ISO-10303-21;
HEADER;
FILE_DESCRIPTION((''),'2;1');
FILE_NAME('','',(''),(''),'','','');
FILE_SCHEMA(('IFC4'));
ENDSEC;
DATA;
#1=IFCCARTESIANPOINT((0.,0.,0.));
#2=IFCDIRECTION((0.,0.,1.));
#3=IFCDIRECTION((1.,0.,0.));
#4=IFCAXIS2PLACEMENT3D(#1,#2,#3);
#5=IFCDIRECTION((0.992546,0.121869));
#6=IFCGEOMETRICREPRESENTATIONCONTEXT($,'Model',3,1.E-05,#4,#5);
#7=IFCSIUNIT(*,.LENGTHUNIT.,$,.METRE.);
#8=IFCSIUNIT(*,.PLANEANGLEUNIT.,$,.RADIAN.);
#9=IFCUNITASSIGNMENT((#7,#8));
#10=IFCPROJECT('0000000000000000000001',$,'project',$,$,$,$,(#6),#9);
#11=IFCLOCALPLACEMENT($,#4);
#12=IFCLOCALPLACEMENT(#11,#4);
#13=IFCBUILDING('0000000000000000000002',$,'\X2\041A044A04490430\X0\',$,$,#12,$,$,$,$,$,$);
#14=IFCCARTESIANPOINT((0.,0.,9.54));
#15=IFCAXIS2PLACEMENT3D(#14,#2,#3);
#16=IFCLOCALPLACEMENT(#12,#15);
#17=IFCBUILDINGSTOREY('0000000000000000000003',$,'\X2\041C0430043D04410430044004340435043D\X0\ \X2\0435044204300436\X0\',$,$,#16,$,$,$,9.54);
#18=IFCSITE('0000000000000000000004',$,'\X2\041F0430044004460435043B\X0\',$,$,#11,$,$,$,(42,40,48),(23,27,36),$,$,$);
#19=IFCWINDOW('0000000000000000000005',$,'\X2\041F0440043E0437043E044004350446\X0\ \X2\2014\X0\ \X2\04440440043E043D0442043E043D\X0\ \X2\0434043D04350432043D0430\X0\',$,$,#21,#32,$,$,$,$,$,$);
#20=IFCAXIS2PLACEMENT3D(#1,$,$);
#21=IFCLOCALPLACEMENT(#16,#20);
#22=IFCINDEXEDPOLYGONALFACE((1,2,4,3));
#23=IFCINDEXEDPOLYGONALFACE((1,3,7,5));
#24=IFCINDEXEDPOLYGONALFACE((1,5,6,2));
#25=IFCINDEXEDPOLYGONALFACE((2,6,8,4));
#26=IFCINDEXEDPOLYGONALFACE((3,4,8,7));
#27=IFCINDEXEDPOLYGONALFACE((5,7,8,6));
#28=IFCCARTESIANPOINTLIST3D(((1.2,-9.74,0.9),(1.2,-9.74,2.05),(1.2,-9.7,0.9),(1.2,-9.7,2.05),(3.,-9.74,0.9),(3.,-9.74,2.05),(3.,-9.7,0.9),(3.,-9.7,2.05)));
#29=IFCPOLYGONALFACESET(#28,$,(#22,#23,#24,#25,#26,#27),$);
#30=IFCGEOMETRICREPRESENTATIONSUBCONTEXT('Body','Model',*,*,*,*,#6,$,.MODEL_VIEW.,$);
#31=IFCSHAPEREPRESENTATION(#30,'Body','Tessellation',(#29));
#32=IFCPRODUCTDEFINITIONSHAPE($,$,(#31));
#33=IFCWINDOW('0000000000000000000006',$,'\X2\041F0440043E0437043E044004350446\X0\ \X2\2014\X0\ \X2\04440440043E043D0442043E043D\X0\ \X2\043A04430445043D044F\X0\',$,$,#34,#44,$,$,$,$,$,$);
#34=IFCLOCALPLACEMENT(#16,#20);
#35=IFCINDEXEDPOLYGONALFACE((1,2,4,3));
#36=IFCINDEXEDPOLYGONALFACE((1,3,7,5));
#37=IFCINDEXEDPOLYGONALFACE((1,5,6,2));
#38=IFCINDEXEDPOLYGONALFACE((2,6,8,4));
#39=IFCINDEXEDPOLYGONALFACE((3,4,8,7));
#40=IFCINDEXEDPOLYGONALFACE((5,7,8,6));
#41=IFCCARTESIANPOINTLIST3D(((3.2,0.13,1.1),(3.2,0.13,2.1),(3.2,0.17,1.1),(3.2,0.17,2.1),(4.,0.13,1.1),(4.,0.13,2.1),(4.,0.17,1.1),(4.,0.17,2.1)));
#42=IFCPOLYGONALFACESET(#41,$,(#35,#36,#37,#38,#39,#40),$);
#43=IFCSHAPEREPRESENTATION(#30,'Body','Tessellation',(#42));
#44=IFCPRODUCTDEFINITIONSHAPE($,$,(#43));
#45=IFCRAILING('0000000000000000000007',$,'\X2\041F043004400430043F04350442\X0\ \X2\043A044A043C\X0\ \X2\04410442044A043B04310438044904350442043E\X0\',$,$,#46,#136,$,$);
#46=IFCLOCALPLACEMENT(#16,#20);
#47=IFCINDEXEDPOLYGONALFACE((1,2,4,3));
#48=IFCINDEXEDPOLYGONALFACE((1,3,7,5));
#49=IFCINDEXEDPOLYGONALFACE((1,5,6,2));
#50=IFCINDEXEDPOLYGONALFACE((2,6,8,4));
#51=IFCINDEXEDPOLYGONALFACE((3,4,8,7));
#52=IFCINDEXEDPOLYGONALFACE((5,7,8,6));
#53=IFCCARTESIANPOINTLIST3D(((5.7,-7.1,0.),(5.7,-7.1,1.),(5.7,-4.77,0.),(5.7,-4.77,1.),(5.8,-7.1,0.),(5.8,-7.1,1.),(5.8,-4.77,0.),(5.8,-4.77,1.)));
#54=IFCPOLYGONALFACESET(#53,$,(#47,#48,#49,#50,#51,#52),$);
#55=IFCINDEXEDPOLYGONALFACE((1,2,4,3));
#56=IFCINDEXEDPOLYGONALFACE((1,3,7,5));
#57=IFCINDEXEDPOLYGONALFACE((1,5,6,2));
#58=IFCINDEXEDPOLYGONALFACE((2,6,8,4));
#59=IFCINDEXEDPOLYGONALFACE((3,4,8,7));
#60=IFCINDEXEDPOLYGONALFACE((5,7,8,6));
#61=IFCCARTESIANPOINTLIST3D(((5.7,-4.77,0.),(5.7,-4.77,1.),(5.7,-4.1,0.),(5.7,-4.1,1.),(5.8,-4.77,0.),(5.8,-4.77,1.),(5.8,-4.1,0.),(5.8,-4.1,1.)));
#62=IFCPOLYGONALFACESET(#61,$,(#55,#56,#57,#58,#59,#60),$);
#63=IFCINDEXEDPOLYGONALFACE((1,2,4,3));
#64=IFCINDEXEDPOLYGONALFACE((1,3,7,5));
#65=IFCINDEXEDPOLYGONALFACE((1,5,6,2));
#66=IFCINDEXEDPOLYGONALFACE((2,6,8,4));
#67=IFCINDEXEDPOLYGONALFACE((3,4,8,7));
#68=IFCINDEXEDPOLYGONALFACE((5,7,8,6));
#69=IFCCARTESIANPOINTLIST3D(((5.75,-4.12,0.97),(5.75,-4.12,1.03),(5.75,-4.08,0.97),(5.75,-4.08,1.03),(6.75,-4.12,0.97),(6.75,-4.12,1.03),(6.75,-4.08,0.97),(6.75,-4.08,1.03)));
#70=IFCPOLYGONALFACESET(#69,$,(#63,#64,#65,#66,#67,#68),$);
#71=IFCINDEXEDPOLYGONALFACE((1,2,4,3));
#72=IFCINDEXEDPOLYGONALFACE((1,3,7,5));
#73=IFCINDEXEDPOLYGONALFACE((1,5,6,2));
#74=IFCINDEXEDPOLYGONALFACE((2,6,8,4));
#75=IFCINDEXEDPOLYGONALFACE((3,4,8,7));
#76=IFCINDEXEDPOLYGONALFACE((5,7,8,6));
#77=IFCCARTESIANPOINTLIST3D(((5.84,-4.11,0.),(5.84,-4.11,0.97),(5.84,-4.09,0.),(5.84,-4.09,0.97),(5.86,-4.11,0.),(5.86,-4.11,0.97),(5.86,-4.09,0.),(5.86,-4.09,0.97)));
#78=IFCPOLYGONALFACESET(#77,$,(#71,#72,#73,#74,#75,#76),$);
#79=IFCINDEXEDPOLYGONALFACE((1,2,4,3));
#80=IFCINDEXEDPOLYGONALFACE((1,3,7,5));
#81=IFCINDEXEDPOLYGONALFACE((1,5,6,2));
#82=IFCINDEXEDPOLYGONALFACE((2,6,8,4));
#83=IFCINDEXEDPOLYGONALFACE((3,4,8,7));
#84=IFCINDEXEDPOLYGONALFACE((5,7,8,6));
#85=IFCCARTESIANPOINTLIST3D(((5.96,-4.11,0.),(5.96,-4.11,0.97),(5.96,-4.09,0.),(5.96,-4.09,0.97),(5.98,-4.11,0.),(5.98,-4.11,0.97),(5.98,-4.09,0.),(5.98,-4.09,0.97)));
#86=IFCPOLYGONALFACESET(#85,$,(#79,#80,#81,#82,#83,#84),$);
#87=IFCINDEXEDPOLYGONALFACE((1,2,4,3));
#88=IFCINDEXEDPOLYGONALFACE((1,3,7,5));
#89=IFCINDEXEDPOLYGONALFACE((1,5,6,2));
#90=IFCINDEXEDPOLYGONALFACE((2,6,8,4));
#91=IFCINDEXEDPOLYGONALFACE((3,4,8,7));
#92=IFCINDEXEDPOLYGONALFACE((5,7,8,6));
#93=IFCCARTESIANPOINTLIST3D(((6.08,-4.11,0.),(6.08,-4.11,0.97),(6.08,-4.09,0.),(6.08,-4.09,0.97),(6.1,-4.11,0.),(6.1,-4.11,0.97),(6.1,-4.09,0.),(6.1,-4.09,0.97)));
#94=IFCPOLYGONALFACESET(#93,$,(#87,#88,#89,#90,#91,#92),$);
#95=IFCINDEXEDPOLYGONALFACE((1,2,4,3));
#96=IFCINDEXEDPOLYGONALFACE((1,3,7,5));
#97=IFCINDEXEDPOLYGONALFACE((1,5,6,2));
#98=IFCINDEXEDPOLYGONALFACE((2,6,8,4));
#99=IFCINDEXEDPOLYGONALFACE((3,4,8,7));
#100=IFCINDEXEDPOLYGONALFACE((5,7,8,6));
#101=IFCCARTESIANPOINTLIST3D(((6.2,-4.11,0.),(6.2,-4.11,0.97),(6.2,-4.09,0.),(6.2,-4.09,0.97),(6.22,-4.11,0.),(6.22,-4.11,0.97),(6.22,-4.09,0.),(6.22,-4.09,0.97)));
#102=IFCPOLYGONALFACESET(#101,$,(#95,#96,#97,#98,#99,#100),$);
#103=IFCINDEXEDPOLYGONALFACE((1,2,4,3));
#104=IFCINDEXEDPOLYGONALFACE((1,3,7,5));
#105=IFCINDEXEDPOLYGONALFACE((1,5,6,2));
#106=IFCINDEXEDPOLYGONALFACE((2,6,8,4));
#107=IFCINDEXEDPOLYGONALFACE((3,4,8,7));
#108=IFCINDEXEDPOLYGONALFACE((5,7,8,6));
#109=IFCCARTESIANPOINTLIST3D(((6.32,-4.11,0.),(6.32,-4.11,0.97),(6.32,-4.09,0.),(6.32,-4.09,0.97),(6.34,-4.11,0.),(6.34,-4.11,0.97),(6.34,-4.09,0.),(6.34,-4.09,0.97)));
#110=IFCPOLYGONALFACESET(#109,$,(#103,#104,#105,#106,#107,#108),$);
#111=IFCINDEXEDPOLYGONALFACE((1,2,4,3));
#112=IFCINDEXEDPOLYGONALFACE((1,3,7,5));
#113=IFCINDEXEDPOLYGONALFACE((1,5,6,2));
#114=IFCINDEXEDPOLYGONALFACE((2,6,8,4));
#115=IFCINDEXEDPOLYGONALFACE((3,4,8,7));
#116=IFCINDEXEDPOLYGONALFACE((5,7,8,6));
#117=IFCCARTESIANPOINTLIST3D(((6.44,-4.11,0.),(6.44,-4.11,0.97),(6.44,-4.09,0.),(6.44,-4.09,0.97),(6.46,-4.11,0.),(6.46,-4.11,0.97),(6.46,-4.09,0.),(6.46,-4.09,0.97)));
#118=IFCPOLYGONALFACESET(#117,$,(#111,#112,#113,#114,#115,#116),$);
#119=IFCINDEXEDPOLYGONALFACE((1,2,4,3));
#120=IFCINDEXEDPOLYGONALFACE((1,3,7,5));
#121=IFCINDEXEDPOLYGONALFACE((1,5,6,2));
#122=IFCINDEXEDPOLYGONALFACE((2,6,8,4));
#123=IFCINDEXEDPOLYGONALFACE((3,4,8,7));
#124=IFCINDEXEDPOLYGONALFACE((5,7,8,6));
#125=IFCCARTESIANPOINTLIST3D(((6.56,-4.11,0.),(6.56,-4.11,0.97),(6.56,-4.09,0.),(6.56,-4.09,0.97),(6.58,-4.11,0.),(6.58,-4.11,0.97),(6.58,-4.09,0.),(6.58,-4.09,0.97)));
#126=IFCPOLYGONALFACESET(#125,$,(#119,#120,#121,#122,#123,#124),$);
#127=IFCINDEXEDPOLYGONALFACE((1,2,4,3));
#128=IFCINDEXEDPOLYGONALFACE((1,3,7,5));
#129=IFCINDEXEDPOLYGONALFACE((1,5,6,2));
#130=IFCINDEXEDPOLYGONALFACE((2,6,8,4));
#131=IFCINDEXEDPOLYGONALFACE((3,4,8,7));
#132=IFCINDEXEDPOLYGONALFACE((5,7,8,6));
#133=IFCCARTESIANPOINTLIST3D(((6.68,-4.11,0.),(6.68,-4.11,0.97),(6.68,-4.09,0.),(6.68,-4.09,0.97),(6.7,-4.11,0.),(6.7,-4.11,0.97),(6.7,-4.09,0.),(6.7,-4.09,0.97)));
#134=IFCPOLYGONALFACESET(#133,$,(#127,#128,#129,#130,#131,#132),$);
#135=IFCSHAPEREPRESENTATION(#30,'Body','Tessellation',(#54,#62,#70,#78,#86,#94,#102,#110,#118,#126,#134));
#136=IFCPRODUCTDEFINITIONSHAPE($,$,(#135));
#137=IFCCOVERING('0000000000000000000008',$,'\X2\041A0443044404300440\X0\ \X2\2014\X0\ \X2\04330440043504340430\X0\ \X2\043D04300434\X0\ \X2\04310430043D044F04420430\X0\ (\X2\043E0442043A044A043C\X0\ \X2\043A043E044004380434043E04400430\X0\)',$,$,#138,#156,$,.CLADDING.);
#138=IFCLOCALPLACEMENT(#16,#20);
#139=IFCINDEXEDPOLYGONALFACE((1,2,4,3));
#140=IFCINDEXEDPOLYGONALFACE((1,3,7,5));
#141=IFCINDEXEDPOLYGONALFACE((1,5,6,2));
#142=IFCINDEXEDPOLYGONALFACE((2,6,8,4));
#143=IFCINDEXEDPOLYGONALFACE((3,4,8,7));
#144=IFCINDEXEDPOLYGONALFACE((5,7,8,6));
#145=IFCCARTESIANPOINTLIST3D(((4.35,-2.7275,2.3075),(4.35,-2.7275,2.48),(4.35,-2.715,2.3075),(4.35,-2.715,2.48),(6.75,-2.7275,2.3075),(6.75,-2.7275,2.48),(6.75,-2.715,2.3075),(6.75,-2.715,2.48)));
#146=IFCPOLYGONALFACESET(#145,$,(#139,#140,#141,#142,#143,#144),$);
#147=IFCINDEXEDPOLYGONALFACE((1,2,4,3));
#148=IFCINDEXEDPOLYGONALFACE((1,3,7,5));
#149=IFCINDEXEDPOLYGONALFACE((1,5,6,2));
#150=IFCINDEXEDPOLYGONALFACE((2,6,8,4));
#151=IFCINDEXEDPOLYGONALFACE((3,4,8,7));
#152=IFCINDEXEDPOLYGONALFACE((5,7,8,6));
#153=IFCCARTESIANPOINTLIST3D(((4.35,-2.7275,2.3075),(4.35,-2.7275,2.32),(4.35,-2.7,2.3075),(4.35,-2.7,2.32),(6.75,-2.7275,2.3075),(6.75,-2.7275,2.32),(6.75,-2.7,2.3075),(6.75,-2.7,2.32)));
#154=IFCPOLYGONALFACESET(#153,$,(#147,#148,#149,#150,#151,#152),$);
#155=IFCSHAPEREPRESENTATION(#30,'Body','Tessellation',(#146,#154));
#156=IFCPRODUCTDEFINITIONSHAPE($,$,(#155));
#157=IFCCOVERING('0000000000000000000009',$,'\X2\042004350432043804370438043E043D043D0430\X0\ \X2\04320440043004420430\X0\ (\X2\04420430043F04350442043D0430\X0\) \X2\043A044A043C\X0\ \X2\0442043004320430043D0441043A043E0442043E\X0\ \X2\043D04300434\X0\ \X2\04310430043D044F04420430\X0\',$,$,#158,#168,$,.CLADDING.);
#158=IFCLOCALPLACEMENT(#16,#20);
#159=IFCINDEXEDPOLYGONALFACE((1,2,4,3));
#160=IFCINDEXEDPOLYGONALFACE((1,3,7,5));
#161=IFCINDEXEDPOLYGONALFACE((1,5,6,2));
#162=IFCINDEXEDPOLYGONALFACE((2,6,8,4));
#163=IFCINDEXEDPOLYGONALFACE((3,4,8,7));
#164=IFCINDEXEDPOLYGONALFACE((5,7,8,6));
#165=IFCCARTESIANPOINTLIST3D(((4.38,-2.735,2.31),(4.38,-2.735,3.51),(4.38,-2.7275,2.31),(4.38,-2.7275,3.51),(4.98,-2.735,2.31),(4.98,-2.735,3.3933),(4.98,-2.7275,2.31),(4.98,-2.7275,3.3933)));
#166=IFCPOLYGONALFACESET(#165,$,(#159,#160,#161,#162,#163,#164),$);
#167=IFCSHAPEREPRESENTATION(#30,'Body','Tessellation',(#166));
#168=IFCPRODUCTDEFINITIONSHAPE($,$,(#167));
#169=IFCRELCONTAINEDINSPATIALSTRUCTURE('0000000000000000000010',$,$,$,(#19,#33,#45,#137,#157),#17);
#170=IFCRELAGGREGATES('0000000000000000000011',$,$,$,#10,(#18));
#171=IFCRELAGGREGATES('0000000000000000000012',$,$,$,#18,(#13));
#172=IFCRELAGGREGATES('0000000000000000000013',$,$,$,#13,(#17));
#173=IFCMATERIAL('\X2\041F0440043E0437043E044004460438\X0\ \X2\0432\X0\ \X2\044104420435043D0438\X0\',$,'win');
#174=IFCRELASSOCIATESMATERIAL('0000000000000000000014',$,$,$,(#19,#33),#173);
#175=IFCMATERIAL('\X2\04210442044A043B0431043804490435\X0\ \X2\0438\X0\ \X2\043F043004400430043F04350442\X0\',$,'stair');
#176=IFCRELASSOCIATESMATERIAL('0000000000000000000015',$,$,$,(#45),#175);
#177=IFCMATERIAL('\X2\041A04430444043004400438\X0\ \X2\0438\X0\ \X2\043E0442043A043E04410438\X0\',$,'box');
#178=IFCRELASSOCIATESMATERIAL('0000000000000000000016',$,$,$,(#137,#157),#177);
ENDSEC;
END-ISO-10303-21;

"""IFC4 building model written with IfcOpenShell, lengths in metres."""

from ifc_helpers import new_model, si_unit, direction, frame, origin_with_axes, place, context, subcontext, project, spatial, polyline, outline, extrude, material, element, save


model = new_model("IFC4")

# Units and contexts
model_context = context("Model", 3, precision=1e-05, world=origin_with_axes(), true_north=direction((0.992546, 0.121869)))
body_context = subcontext(model_context, "Body", "Model", "MODEL_VIEW")
ifc_project = project(units=[si_unit("LENGTHUNIT", "METRE"), si_unit("PLANEANGLEUNIT", "RADIAN")], contexts=[model_context])

# Site, building, storey
site_placement = place(None, origin_with_axes())
site = spatial("IfcSite", under=ifc_project, at=site_placement, Name="Парцел", RefLatitude=(42, 40, 48), RefLongitude=(23, 27, 36))
building_placement = place(site_placement, origin_with_axes())
building = spatial("IfcBuilding", under=site, at=building_placement, Name="Къща")
storey_placement = place(building_placement, frame((0.0, 0.0, 9.54), z_axis=(0.0, 0.0, 1.0), x_axis=(1.0, 0.0, 0.0)))
storey = spatial("IfcBuildingStorey", under=building, at=storey_placement, Name="Мансарден етаж", Elevation=9.54)

# Windows
ifc_material_1 = material(Name="Прозорци в стени", Category="win")
window_1_placement = place(storey_placement, origin_with_axes())
element("IfcWindow", 1, at=window_1_placement, inside=storey, material=ifc_material_1, Name="Прозорец — фронтон дневна", context=body_context, shape_type="SweptSolid", body=[
    extrude(outline(polyline([(1.2, -0.9), (3.0, -0.9), (3.0, -2.05), (1.2, -2.05), (1.2, -0.9)])), frame((0.0, -9.74, 0.0), z_axis=(0.0, 1.0, 0.0), x_axis=(1.0, 0.0, 0.0)), (0.0, 0.0, 1.0), 0.04),
])
window_2_placement = place(storey_placement, origin_with_axes())
element("IfcWindow", 2, at=window_2_placement, inside=storey, material=ifc_material_1, Name="Прозорец — фронтон кухня", context=body_context, shape_type="SweptSolid", body=[
    extrude(outline(polyline([(3.2, -1.1), (4.0, -1.1), (4.0, -2.1), (3.2, -2.1), (3.2, -1.1)])), frame((0.0, 0.13, 0.0), z_axis=(0.0, 1.0, 0.0), x_axis=(1.0, 0.0, 0.0)), (0.0, 0.0, 1.0), 0.04),
])

# Shared definitions
ifc_material_2 = material(Name="Стълбище и парапет", Category="stair")

# Railing
railing_placement = place(storey_placement, origin_with_axes())
element("IfcRailing", 3, at=railing_placement, inside=storey, material=ifc_material_2, Name="Парапет към стълбището", context=body_context, shape_type="SweptSolid", body=[
    extrude(outline(polyline([(5.7, 0.0), (5.8, 0.0), (5.8, -1.0), (5.7, -1.0), (5.7, 0.0)])), frame((0.0, -7.1, 0.0), z_axis=(0.0, 1.0, 0.0), x_axis=(1.0, 0.0, 0.0)), (0.0, 0.0, 1.0), 2.33),
    extrude(outline(polyline([(5.7, 0.0), (5.8, 0.0), (5.8, -1.0), (5.7, -1.0), (5.7, 0.0)])), frame((0.0, -4.77, 0.0), z_axis=(0.0, 1.0, 0.0), x_axis=(1.0, 0.0, 0.0)), (0.0, 0.0, 1.0), 0.67),
    extrude(outline(polyline([(5.75, -0.97), (6.75, -0.97), (6.75, -1.03), (5.75, -1.03), (5.75, -0.97)])), frame((0.0, -4.12, 0.0), z_axis=(0.0, 1.0, 0.0), x_axis=(1.0, 0.0, 0.0)), (0.0, 0.0, 1.0), 0.04),
    extrude(outline(polyline([(5.84, 0.0), (5.86, 0.0), (5.86, -0.97), (5.84, -0.97), (5.84, 0.0)])), frame((0.0, -4.11, 0.0), z_axis=(0.0, 1.0, 0.0), x_axis=(1.0, 0.0, 0.0)), (0.0, 0.0, 1.0), 0.02),
    extrude(outline(polyline([(5.96, 0.0), (5.98, 0.0), (5.98, -0.97), (5.96, -0.97), (5.96, 0.0)])), frame((0.0, -4.11, 0.0), z_axis=(0.0, 1.0, 0.0), x_axis=(1.0, 0.0, 0.0)), (0.0, 0.0, 1.0), 0.02),
    extrude(outline(polyline([(6.08, 0.0), (6.1, 0.0), (6.1, -0.97), (6.08, -0.97), (6.08, 0.0)])), frame((0.0, -4.11, 0.0), z_axis=(0.0, 1.0, 0.0), x_axis=(1.0, 0.0, 0.0)), (0.0, 0.0, 1.0), 0.02),
    extrude(outline(polyline([(6.2, 0.0), (6.22, 0.0), (6.22, -0.97), (6.2, -0.97), (6.2, 0.0)])), frame((0.0, -4.11, 0.0), z_axis=(0.0, 1.0, 0.0), x_axis=(1.0, 0.0, 0.0)), (0.0, 0.0, 1.0), 0.02),
    extrude(outline(polyline([(6.32, 0.0), (6.34, 0.0), (6.34, -0.97), (6.32, -0.97), (6.32, 0.0)])), frame((0.0, -4.11, 0.0), z_axis=(0.0, 1.0, 0.0), x_axis=(1.0, 0.0, 0.0)), (0.0, 0.0, 1.0), 0.02),
    extrude(outline(polyline([(6.44, 0.0), (6.46, 0.0), (6.46, -0.97), (6.44, -0.97), (6.44, 0.0)])), frame((0.0, -4.11, 0.0), z_axis=(0.0, 1.0, 0.0), x_axis=(1.0, 0.0, 0.0)), (0.0, 0.0, 1.0), 0.02),
    extrude(outline(polyline([(6.56, 0.0), (6.58, 0.0), (6.58, -0.97), (6.56, -0.97), (6.56, 0.0)])), frame((0.0, -4.11, 0.0), z_axis=(0.0, 1.0, 0.0), x_axis=(1.0, 0.0, 0.0)), (0.0, 0.0, 1.0), 0.02),
    extrude(outline(polyline([(6.68, 0.0), (6.7, 0.0), (6.7, -0.97), (6.68, -0.97), (6.68, 0.0)])), frame((0.0, -4.11, 0.0), z_axis=(0.0, 1.0, 0.0), x_axis=(1.0, 0.0, 0.0)), (0.0, 0.0, 1.0), 0.02),
])

# Coverings
ifc_material_3 = material(Name="Куфари и откоси", Category="box")
covering_1_placement = place(storey_placement, origin_with_axes())
element("IfcCovering", 4, at=covering_1_placement, inside=storey, material=ifc_material_3, Name="Куфар — греда над банята (откъм коридора)", PredefinedType="CLADDING", context=body_context, shape_type="SweptSolid", body=[
    extrude(outline(polyline([(4.35, -2.3075), (6.75, -2.3075), (6.75, -2.48), (4.35, -2.48), (4.35, -2.3075)])), frame((0.0, -2.7275, 0.0), z_axis=(0.0, 1.0, 0.0), x_axis=(1.0, 0.0, 0.0)), (0.0, 0.0, 1.0), 0.0125),
    extrude(outline(polyline([(4.35, -2.3075), (6.75, -2.3075), (6.75, -2.32), (4.35, -2.32), (4.35, -2.3075)])), frame((0.0, -2.7275, 0.0), z_axis=(0.0, 1.0, 0.0), x_axis=(1.0, 0.0, 0.0)), (0.0, 0.0, 1.0), 0.0275),
])
covering_2_placement = place(storey_placement, origin_with_axes())
element("IfcCovering", 5, at=covering_2_placement, inside=storey, material=ifc_material_3, Name="Ревизионна врата (тапетна) към таванското над банята", PredefinedType="CLADDING", context=body_context, shape_type="SweptSolid", body=[
    extrude(outline(polyline([(4.38, -2.31), (4.98, -2.31), (4.98, -3.3933), (4.38, -3.51), (4.38, -2.31)])), frame((0.0, -2.735, 0.0), z_axis=(0.0, 1.0, 0.0), x_axis=(1.0, 0.0, 0.0)), (0.0, 0.0, 1.0), 0.0075),
])

save(model, "model.ifc")
